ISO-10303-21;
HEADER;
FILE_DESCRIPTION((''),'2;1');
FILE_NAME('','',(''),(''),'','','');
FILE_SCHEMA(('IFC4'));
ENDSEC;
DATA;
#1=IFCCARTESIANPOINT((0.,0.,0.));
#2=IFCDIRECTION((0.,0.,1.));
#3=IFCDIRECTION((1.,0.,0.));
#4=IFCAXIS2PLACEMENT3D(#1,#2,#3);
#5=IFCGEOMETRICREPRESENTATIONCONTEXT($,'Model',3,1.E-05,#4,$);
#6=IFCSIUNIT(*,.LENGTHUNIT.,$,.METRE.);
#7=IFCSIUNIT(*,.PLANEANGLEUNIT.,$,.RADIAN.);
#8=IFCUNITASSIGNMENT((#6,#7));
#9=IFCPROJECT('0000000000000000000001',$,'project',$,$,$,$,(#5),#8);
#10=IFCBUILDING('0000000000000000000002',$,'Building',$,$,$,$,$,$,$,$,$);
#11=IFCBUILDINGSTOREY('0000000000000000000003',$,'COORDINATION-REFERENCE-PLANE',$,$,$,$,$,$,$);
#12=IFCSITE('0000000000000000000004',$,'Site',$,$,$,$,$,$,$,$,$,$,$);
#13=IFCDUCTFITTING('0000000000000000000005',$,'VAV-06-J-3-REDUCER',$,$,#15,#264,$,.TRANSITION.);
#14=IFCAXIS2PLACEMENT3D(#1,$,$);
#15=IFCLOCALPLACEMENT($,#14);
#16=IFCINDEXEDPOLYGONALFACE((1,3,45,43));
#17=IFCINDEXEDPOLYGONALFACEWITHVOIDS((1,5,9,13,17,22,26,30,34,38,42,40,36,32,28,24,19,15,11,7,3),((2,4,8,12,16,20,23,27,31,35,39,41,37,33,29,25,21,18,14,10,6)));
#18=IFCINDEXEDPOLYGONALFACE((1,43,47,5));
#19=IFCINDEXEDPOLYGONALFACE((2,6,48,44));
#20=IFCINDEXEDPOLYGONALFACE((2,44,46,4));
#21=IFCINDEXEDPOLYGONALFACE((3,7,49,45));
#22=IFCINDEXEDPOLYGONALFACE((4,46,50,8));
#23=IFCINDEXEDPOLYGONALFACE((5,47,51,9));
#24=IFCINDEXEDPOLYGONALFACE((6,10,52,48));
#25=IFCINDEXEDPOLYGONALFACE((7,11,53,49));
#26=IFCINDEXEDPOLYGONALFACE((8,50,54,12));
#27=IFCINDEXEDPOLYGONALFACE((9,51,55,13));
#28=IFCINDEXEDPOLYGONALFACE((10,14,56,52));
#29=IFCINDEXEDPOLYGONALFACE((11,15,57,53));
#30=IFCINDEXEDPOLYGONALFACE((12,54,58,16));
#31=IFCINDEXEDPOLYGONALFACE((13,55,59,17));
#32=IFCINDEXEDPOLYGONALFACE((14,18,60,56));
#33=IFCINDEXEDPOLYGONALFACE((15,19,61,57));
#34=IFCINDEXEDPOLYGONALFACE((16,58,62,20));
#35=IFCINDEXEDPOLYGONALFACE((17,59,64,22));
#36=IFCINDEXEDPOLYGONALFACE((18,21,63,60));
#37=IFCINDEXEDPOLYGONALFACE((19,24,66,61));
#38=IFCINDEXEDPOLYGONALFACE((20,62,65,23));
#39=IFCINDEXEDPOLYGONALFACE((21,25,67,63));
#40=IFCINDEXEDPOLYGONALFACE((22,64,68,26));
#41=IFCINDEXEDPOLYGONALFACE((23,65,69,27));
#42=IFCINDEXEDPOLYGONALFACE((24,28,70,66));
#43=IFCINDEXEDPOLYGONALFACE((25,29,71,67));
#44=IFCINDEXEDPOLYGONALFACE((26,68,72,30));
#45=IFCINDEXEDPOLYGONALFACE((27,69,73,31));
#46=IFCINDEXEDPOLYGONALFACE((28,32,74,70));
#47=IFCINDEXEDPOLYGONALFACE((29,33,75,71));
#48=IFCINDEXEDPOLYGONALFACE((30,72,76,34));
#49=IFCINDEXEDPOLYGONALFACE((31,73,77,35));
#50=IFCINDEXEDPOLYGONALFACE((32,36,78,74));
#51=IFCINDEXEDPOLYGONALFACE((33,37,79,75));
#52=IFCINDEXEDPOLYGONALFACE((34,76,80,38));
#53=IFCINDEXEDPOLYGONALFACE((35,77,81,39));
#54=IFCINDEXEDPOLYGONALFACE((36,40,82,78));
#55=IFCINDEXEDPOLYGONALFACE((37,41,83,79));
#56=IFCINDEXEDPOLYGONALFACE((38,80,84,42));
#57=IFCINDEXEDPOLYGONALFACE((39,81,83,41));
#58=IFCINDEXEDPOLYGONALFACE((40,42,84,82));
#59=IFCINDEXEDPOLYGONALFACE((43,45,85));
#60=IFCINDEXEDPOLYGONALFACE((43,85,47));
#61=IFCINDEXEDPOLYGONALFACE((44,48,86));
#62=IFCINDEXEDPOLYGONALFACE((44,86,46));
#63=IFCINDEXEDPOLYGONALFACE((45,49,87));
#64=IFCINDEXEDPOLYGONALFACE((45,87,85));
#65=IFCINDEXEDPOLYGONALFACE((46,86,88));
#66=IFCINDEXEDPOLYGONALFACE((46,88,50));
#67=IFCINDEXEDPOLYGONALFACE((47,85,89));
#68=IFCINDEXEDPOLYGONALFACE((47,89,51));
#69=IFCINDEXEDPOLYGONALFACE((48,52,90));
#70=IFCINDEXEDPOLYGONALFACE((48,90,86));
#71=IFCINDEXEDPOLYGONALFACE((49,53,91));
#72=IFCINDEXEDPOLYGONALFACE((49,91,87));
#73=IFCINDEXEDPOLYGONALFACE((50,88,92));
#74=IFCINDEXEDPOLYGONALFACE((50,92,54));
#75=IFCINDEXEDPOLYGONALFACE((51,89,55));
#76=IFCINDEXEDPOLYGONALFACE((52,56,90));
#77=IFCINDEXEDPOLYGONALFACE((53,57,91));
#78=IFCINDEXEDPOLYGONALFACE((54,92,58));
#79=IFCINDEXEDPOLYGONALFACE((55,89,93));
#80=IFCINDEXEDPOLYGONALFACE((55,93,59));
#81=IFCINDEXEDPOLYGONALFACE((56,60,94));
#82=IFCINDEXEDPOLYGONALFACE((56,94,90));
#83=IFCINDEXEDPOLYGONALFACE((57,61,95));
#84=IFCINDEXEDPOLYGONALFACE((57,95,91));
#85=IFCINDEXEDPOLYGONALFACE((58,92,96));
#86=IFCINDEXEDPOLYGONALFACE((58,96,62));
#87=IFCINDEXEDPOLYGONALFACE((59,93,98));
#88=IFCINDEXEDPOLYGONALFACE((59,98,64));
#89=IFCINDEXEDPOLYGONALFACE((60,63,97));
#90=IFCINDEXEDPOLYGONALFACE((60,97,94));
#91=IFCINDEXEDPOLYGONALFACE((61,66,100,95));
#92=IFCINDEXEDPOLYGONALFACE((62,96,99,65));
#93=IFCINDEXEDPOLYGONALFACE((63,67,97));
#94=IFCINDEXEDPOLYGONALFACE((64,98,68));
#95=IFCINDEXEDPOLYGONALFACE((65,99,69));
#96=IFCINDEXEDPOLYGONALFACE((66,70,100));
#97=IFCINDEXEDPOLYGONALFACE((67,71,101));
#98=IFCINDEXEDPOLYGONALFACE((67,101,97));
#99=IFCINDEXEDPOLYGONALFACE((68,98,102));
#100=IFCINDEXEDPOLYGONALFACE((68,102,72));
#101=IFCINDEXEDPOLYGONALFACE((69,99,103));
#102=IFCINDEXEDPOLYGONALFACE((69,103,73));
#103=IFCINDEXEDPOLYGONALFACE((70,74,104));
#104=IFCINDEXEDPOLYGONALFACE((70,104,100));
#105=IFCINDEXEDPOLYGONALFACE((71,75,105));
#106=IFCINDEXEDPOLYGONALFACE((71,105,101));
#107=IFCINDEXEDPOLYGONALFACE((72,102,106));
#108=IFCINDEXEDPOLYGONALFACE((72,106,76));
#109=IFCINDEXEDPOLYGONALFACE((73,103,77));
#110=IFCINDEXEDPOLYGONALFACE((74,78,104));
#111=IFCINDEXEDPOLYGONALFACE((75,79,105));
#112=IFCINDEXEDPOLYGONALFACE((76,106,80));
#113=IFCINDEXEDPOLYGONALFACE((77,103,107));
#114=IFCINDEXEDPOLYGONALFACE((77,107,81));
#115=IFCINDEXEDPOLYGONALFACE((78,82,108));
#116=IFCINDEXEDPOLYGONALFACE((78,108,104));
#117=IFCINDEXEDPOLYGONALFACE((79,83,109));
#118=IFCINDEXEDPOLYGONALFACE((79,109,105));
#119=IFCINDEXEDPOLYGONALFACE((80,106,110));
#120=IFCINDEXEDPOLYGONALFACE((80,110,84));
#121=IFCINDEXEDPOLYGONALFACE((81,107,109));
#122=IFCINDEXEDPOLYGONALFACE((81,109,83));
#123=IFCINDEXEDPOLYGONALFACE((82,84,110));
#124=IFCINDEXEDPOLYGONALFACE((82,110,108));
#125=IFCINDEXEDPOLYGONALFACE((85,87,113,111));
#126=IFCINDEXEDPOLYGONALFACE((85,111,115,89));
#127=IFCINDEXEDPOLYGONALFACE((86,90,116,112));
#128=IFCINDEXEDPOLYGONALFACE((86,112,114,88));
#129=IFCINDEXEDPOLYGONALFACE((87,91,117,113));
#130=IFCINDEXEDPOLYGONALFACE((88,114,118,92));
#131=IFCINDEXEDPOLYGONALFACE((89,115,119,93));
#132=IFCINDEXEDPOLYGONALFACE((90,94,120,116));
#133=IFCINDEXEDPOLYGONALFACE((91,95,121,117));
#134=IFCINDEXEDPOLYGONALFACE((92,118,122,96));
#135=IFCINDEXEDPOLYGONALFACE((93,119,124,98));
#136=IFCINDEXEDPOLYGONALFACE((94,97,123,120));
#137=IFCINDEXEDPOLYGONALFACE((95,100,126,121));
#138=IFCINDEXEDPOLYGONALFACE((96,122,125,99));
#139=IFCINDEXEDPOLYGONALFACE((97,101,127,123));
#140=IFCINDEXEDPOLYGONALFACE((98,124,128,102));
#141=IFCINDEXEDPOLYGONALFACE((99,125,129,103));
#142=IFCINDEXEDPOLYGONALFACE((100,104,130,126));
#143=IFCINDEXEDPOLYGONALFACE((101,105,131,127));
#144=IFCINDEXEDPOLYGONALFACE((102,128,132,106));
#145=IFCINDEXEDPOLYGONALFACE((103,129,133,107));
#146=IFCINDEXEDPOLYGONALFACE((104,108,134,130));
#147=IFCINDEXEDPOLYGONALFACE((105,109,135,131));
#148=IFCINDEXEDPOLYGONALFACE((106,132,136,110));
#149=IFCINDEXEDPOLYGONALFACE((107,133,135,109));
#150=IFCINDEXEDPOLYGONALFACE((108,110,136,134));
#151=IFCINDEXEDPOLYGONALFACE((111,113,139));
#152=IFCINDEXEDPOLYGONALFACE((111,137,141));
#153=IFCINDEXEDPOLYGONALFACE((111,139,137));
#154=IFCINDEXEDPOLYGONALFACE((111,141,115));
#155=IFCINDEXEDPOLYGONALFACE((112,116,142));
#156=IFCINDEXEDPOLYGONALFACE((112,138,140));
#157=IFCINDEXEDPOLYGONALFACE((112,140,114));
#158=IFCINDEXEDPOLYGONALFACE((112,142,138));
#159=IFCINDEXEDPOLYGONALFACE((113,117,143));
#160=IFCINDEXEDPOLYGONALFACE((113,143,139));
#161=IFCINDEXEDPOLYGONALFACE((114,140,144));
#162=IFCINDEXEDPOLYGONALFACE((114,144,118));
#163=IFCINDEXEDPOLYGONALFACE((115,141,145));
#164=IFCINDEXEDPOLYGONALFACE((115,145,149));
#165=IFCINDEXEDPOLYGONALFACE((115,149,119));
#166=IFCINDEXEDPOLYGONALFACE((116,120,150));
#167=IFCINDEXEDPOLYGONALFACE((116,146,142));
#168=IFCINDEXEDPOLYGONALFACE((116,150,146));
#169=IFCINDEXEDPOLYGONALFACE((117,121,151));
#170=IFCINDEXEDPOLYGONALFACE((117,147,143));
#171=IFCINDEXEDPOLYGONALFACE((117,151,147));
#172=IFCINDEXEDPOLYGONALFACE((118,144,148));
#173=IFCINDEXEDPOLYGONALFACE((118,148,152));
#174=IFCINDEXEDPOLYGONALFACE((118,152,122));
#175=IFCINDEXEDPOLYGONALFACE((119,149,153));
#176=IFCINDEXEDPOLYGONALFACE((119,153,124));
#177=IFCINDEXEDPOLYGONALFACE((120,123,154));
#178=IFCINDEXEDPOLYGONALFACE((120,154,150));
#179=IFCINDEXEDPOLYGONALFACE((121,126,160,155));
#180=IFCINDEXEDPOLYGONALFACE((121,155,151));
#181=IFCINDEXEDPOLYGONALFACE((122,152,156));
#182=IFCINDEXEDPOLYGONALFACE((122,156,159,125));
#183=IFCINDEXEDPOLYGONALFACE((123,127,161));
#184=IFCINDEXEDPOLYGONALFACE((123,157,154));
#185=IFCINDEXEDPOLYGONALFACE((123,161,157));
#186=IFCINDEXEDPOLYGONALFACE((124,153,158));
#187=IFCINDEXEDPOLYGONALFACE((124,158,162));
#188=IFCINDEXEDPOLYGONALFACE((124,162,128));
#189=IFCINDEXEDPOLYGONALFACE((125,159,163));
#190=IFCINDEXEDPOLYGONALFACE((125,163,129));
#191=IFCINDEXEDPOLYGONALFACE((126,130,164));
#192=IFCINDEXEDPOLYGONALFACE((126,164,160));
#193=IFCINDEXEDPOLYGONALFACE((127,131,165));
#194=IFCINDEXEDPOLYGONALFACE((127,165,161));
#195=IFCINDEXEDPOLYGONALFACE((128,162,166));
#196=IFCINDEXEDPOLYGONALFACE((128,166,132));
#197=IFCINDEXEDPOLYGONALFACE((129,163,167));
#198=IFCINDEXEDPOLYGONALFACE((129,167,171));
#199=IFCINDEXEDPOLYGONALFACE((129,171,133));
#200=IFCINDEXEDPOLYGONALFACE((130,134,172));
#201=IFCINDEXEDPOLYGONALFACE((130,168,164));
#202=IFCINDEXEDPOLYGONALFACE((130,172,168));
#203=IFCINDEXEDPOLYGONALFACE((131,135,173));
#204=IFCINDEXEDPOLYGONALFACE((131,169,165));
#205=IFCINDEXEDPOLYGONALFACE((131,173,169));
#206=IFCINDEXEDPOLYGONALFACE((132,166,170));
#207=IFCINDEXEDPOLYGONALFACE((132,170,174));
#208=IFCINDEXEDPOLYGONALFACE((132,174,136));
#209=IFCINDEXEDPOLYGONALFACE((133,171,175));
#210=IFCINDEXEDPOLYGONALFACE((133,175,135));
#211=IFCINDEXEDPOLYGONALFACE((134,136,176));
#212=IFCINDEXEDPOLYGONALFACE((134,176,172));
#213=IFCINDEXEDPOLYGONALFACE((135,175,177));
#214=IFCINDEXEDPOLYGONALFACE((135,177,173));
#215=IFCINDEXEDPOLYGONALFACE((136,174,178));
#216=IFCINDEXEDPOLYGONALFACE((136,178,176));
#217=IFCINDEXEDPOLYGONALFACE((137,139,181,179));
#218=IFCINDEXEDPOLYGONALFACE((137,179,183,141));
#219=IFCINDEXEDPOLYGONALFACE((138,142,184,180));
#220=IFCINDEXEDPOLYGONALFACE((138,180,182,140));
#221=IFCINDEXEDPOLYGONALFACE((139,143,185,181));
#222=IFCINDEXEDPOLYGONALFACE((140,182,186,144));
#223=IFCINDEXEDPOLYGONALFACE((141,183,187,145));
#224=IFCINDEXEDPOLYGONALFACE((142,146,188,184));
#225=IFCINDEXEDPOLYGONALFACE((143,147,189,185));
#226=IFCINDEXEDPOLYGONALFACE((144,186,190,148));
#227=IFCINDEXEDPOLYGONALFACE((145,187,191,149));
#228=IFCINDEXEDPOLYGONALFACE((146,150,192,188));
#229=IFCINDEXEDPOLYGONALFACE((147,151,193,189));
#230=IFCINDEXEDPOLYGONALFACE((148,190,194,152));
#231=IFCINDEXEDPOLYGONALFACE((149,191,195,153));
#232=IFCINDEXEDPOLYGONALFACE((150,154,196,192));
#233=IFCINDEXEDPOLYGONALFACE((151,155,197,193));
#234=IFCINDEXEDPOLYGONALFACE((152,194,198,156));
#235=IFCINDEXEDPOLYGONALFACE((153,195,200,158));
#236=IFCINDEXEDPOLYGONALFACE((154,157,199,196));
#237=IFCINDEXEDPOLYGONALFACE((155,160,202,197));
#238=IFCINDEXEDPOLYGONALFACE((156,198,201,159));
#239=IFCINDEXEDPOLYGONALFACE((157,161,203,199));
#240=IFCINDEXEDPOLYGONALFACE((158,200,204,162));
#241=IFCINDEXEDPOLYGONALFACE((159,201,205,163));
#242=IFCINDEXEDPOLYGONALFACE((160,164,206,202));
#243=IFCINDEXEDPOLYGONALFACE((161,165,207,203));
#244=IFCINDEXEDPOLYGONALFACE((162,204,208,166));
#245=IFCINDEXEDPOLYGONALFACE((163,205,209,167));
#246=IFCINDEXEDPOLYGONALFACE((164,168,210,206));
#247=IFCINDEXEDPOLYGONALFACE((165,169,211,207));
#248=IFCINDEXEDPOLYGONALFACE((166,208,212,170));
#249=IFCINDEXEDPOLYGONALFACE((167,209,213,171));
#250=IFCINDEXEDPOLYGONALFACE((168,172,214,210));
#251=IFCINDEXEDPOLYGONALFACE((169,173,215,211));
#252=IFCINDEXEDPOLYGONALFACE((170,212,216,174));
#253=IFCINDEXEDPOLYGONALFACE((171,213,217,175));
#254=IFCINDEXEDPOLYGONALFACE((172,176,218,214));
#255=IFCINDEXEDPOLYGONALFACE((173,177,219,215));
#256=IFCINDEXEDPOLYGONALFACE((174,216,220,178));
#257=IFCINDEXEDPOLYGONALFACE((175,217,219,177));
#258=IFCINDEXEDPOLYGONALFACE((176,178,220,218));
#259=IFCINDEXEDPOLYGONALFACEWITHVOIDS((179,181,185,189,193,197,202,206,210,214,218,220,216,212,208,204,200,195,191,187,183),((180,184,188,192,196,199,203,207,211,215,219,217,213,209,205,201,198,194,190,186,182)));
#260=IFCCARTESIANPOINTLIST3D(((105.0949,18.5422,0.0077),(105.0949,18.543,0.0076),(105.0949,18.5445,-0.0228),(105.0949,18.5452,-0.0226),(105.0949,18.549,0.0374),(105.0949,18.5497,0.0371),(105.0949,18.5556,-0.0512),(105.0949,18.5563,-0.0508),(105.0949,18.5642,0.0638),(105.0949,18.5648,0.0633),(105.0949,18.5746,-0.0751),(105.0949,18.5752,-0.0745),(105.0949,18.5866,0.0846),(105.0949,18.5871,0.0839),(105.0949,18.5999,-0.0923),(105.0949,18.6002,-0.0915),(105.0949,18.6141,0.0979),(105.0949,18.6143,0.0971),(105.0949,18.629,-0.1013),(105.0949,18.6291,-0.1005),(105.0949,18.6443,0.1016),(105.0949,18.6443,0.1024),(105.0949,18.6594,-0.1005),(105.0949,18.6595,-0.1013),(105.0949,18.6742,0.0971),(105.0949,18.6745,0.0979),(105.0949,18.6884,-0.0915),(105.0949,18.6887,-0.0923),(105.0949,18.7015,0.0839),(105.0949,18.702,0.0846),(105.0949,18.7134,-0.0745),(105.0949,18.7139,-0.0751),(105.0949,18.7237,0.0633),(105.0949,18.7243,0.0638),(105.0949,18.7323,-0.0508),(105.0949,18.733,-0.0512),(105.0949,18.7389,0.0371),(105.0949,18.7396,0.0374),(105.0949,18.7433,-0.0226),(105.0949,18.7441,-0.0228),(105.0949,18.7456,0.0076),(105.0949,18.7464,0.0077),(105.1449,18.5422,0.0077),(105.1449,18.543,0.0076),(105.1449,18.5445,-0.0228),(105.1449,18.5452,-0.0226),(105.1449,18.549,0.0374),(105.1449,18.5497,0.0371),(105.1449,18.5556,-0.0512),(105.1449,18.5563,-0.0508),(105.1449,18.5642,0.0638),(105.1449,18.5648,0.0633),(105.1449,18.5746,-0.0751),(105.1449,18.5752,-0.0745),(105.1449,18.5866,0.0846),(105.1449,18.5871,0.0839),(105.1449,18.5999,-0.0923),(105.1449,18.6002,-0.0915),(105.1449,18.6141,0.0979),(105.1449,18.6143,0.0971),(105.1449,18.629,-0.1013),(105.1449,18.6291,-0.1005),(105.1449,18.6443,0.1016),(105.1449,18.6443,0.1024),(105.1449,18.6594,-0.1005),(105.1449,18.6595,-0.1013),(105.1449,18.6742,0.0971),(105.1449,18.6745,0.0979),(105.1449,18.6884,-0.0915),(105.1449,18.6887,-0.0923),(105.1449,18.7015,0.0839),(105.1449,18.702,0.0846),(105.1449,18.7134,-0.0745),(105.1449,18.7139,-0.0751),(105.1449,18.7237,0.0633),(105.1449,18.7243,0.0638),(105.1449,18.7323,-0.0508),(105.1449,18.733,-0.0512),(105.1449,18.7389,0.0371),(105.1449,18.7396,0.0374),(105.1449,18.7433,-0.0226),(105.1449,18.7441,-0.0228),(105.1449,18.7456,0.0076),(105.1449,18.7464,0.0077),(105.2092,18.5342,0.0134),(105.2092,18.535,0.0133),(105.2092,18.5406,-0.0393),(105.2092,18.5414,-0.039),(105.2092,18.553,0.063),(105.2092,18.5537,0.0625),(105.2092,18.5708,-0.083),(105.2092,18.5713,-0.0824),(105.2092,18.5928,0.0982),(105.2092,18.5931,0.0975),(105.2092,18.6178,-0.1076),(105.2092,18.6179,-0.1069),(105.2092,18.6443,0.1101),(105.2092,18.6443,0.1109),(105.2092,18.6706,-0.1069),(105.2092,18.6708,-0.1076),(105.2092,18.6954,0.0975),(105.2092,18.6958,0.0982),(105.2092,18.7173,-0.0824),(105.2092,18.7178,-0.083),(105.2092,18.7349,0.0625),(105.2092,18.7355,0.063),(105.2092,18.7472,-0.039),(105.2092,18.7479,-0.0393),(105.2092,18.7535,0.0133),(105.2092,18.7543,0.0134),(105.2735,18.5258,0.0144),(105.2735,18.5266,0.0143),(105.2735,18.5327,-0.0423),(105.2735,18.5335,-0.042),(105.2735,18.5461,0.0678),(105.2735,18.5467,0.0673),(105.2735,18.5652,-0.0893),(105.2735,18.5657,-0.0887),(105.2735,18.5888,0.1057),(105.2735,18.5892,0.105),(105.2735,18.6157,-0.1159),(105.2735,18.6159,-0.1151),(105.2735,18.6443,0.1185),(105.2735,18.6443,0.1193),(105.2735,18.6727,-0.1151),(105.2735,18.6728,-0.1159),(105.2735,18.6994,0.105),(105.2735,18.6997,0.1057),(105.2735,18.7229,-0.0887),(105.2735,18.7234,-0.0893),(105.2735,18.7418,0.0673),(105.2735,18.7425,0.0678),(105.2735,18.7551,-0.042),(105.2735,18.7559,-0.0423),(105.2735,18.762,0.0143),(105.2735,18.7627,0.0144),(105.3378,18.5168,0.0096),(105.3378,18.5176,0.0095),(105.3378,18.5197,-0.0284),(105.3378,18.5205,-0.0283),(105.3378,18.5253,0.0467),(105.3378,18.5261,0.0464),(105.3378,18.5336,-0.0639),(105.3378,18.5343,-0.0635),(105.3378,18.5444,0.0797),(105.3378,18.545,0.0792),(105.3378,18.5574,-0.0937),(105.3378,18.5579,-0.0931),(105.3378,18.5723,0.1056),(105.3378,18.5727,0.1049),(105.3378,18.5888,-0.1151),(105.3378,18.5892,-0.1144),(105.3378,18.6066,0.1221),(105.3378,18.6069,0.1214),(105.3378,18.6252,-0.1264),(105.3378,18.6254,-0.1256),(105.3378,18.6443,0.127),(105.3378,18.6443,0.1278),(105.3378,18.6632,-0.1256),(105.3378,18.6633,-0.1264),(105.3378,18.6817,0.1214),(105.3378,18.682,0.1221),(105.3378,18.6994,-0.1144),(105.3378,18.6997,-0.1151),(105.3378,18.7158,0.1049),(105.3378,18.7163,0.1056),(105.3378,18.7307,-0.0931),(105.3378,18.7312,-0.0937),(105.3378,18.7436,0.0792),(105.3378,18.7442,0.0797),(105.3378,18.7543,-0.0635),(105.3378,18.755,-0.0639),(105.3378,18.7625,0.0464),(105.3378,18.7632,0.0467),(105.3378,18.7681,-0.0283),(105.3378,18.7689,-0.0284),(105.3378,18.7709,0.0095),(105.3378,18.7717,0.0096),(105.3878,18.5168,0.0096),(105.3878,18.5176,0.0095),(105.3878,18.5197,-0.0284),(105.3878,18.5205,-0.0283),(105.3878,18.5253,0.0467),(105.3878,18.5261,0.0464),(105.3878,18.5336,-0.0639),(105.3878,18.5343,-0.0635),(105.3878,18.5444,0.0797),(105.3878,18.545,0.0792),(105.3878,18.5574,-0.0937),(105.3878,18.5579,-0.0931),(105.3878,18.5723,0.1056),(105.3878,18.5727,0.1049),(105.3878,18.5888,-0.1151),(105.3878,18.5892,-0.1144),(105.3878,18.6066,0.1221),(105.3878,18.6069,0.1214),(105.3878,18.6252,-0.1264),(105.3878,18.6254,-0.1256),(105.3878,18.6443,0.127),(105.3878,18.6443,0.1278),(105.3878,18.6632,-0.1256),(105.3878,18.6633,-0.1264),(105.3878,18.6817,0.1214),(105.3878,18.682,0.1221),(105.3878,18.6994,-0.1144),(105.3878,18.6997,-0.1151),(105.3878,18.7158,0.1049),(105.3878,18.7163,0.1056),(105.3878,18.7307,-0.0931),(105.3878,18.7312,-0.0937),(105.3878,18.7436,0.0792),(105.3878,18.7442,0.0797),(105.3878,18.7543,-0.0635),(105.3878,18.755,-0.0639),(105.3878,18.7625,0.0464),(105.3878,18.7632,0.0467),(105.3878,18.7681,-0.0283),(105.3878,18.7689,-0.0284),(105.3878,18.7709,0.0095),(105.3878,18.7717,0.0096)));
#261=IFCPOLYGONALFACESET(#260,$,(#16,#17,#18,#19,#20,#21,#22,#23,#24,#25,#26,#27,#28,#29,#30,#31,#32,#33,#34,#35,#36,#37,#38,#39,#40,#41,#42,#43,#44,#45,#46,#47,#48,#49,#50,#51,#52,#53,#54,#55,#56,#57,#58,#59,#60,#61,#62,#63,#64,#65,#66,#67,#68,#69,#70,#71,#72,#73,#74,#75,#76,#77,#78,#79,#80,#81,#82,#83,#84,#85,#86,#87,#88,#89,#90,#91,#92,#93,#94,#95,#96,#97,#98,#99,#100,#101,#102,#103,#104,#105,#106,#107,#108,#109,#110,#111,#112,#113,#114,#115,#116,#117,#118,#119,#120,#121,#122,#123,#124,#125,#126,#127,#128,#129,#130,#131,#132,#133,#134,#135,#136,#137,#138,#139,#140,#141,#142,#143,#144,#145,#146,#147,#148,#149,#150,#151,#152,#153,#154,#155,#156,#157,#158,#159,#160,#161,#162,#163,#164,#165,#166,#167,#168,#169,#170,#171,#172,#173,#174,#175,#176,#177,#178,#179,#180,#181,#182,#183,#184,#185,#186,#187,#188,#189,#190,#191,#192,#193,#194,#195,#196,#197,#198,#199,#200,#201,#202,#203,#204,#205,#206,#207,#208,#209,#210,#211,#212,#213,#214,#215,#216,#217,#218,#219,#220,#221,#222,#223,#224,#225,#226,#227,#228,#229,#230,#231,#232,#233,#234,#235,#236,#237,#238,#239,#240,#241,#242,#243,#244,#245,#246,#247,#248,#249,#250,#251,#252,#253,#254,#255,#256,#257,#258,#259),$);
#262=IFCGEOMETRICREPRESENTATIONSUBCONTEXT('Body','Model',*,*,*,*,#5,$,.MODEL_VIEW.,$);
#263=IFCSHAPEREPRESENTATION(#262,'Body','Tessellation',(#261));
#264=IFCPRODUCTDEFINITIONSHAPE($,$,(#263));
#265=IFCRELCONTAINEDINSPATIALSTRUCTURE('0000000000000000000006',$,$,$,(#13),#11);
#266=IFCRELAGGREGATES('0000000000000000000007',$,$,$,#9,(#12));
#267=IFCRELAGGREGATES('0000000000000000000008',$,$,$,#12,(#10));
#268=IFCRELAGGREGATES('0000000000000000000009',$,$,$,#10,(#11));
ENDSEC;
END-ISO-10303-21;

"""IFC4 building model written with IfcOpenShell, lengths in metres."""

from ifc_helpers import new_model, entity, si_unit, frame, origin_with_axes, place, context, subcontext, project, spatial, element, save


model = new_model("IFC4")

# Units and contexts
model_context_1 = context("Model", 3, precision=1e-05, world=origin_with_axes())
body_context_1 = subcontext(model_context_1, "Body", "Model", "MODEL_VIEW")
ifc_project = project(units=[si_unit("LENGTHUNIT", "METRE"), si_unit("PLANEANGLEUNIT", "RADIAN")], contexts=[model_context_1])

# Site, building, storey
site = spatial("IfcSite", under=ifc_project, Name="Site")
building = spatial("IfcBuilding", under=site, Name="Building")
storey = spatial("IfcBuildingStorey", under=building, Name="COORDINATION-REFERENCE-PLANE")

# Duct fitting
for number, where, z_axis, x_axis, name in (
    (1, (105.3878, 18.6443, 0.0), (0.0, -1.0, 0.0), (0.0, 0.0, 1.0), "VAV-06-J-3-REDUCER"),
):
    element("IfcDuctFitting", number, at=place(None, frame(where, z_axis=z_axis, x_axis=x_axis)), inside=storey, Name=name, PredefinedType="TRANSITION", context=body_context_1, shape_type="SweptSolid", body=[
        entity("IfcRevolvedAreaSolid", entity("IfcArbitraryClosedProfileDef", "AREA", None, entity("IfcPolyline", [entity("IfcCartesianPoint", [0.1278, 0.0]), entity("IfcCartesianPoint", [0.1278, 0.05]), entity("IfcCartesianPoint", [0.1024, 0.2429]), entity("IfcCartesianPoint", [0.1024, 0.2929]), entity("IfcCartesianPoint", [0.1016, 0.2929]), entity("IfcCartesianPoint", [0.1016, 0.2429]), entity("IfcCartesianPoint", [0.127, 0.05]), entity("IfcCartesianPoint", [0.127, 0.0]), entity("IfcCartesianPoint", [0.1278, 0.0])])), entity("IfcAxis2Placement3D", entity("IfcCartesianPoint", [0.0, 0.0, 0.0])), entity("IfcAxis1Placement", entity("IfcCartesianPoint", [0.0, 0.0, 0.0]), entity("IfcDirection", [0.0, 1.0, 0.0])), 6.283185),
    ])

save(model, "model.ifc")
